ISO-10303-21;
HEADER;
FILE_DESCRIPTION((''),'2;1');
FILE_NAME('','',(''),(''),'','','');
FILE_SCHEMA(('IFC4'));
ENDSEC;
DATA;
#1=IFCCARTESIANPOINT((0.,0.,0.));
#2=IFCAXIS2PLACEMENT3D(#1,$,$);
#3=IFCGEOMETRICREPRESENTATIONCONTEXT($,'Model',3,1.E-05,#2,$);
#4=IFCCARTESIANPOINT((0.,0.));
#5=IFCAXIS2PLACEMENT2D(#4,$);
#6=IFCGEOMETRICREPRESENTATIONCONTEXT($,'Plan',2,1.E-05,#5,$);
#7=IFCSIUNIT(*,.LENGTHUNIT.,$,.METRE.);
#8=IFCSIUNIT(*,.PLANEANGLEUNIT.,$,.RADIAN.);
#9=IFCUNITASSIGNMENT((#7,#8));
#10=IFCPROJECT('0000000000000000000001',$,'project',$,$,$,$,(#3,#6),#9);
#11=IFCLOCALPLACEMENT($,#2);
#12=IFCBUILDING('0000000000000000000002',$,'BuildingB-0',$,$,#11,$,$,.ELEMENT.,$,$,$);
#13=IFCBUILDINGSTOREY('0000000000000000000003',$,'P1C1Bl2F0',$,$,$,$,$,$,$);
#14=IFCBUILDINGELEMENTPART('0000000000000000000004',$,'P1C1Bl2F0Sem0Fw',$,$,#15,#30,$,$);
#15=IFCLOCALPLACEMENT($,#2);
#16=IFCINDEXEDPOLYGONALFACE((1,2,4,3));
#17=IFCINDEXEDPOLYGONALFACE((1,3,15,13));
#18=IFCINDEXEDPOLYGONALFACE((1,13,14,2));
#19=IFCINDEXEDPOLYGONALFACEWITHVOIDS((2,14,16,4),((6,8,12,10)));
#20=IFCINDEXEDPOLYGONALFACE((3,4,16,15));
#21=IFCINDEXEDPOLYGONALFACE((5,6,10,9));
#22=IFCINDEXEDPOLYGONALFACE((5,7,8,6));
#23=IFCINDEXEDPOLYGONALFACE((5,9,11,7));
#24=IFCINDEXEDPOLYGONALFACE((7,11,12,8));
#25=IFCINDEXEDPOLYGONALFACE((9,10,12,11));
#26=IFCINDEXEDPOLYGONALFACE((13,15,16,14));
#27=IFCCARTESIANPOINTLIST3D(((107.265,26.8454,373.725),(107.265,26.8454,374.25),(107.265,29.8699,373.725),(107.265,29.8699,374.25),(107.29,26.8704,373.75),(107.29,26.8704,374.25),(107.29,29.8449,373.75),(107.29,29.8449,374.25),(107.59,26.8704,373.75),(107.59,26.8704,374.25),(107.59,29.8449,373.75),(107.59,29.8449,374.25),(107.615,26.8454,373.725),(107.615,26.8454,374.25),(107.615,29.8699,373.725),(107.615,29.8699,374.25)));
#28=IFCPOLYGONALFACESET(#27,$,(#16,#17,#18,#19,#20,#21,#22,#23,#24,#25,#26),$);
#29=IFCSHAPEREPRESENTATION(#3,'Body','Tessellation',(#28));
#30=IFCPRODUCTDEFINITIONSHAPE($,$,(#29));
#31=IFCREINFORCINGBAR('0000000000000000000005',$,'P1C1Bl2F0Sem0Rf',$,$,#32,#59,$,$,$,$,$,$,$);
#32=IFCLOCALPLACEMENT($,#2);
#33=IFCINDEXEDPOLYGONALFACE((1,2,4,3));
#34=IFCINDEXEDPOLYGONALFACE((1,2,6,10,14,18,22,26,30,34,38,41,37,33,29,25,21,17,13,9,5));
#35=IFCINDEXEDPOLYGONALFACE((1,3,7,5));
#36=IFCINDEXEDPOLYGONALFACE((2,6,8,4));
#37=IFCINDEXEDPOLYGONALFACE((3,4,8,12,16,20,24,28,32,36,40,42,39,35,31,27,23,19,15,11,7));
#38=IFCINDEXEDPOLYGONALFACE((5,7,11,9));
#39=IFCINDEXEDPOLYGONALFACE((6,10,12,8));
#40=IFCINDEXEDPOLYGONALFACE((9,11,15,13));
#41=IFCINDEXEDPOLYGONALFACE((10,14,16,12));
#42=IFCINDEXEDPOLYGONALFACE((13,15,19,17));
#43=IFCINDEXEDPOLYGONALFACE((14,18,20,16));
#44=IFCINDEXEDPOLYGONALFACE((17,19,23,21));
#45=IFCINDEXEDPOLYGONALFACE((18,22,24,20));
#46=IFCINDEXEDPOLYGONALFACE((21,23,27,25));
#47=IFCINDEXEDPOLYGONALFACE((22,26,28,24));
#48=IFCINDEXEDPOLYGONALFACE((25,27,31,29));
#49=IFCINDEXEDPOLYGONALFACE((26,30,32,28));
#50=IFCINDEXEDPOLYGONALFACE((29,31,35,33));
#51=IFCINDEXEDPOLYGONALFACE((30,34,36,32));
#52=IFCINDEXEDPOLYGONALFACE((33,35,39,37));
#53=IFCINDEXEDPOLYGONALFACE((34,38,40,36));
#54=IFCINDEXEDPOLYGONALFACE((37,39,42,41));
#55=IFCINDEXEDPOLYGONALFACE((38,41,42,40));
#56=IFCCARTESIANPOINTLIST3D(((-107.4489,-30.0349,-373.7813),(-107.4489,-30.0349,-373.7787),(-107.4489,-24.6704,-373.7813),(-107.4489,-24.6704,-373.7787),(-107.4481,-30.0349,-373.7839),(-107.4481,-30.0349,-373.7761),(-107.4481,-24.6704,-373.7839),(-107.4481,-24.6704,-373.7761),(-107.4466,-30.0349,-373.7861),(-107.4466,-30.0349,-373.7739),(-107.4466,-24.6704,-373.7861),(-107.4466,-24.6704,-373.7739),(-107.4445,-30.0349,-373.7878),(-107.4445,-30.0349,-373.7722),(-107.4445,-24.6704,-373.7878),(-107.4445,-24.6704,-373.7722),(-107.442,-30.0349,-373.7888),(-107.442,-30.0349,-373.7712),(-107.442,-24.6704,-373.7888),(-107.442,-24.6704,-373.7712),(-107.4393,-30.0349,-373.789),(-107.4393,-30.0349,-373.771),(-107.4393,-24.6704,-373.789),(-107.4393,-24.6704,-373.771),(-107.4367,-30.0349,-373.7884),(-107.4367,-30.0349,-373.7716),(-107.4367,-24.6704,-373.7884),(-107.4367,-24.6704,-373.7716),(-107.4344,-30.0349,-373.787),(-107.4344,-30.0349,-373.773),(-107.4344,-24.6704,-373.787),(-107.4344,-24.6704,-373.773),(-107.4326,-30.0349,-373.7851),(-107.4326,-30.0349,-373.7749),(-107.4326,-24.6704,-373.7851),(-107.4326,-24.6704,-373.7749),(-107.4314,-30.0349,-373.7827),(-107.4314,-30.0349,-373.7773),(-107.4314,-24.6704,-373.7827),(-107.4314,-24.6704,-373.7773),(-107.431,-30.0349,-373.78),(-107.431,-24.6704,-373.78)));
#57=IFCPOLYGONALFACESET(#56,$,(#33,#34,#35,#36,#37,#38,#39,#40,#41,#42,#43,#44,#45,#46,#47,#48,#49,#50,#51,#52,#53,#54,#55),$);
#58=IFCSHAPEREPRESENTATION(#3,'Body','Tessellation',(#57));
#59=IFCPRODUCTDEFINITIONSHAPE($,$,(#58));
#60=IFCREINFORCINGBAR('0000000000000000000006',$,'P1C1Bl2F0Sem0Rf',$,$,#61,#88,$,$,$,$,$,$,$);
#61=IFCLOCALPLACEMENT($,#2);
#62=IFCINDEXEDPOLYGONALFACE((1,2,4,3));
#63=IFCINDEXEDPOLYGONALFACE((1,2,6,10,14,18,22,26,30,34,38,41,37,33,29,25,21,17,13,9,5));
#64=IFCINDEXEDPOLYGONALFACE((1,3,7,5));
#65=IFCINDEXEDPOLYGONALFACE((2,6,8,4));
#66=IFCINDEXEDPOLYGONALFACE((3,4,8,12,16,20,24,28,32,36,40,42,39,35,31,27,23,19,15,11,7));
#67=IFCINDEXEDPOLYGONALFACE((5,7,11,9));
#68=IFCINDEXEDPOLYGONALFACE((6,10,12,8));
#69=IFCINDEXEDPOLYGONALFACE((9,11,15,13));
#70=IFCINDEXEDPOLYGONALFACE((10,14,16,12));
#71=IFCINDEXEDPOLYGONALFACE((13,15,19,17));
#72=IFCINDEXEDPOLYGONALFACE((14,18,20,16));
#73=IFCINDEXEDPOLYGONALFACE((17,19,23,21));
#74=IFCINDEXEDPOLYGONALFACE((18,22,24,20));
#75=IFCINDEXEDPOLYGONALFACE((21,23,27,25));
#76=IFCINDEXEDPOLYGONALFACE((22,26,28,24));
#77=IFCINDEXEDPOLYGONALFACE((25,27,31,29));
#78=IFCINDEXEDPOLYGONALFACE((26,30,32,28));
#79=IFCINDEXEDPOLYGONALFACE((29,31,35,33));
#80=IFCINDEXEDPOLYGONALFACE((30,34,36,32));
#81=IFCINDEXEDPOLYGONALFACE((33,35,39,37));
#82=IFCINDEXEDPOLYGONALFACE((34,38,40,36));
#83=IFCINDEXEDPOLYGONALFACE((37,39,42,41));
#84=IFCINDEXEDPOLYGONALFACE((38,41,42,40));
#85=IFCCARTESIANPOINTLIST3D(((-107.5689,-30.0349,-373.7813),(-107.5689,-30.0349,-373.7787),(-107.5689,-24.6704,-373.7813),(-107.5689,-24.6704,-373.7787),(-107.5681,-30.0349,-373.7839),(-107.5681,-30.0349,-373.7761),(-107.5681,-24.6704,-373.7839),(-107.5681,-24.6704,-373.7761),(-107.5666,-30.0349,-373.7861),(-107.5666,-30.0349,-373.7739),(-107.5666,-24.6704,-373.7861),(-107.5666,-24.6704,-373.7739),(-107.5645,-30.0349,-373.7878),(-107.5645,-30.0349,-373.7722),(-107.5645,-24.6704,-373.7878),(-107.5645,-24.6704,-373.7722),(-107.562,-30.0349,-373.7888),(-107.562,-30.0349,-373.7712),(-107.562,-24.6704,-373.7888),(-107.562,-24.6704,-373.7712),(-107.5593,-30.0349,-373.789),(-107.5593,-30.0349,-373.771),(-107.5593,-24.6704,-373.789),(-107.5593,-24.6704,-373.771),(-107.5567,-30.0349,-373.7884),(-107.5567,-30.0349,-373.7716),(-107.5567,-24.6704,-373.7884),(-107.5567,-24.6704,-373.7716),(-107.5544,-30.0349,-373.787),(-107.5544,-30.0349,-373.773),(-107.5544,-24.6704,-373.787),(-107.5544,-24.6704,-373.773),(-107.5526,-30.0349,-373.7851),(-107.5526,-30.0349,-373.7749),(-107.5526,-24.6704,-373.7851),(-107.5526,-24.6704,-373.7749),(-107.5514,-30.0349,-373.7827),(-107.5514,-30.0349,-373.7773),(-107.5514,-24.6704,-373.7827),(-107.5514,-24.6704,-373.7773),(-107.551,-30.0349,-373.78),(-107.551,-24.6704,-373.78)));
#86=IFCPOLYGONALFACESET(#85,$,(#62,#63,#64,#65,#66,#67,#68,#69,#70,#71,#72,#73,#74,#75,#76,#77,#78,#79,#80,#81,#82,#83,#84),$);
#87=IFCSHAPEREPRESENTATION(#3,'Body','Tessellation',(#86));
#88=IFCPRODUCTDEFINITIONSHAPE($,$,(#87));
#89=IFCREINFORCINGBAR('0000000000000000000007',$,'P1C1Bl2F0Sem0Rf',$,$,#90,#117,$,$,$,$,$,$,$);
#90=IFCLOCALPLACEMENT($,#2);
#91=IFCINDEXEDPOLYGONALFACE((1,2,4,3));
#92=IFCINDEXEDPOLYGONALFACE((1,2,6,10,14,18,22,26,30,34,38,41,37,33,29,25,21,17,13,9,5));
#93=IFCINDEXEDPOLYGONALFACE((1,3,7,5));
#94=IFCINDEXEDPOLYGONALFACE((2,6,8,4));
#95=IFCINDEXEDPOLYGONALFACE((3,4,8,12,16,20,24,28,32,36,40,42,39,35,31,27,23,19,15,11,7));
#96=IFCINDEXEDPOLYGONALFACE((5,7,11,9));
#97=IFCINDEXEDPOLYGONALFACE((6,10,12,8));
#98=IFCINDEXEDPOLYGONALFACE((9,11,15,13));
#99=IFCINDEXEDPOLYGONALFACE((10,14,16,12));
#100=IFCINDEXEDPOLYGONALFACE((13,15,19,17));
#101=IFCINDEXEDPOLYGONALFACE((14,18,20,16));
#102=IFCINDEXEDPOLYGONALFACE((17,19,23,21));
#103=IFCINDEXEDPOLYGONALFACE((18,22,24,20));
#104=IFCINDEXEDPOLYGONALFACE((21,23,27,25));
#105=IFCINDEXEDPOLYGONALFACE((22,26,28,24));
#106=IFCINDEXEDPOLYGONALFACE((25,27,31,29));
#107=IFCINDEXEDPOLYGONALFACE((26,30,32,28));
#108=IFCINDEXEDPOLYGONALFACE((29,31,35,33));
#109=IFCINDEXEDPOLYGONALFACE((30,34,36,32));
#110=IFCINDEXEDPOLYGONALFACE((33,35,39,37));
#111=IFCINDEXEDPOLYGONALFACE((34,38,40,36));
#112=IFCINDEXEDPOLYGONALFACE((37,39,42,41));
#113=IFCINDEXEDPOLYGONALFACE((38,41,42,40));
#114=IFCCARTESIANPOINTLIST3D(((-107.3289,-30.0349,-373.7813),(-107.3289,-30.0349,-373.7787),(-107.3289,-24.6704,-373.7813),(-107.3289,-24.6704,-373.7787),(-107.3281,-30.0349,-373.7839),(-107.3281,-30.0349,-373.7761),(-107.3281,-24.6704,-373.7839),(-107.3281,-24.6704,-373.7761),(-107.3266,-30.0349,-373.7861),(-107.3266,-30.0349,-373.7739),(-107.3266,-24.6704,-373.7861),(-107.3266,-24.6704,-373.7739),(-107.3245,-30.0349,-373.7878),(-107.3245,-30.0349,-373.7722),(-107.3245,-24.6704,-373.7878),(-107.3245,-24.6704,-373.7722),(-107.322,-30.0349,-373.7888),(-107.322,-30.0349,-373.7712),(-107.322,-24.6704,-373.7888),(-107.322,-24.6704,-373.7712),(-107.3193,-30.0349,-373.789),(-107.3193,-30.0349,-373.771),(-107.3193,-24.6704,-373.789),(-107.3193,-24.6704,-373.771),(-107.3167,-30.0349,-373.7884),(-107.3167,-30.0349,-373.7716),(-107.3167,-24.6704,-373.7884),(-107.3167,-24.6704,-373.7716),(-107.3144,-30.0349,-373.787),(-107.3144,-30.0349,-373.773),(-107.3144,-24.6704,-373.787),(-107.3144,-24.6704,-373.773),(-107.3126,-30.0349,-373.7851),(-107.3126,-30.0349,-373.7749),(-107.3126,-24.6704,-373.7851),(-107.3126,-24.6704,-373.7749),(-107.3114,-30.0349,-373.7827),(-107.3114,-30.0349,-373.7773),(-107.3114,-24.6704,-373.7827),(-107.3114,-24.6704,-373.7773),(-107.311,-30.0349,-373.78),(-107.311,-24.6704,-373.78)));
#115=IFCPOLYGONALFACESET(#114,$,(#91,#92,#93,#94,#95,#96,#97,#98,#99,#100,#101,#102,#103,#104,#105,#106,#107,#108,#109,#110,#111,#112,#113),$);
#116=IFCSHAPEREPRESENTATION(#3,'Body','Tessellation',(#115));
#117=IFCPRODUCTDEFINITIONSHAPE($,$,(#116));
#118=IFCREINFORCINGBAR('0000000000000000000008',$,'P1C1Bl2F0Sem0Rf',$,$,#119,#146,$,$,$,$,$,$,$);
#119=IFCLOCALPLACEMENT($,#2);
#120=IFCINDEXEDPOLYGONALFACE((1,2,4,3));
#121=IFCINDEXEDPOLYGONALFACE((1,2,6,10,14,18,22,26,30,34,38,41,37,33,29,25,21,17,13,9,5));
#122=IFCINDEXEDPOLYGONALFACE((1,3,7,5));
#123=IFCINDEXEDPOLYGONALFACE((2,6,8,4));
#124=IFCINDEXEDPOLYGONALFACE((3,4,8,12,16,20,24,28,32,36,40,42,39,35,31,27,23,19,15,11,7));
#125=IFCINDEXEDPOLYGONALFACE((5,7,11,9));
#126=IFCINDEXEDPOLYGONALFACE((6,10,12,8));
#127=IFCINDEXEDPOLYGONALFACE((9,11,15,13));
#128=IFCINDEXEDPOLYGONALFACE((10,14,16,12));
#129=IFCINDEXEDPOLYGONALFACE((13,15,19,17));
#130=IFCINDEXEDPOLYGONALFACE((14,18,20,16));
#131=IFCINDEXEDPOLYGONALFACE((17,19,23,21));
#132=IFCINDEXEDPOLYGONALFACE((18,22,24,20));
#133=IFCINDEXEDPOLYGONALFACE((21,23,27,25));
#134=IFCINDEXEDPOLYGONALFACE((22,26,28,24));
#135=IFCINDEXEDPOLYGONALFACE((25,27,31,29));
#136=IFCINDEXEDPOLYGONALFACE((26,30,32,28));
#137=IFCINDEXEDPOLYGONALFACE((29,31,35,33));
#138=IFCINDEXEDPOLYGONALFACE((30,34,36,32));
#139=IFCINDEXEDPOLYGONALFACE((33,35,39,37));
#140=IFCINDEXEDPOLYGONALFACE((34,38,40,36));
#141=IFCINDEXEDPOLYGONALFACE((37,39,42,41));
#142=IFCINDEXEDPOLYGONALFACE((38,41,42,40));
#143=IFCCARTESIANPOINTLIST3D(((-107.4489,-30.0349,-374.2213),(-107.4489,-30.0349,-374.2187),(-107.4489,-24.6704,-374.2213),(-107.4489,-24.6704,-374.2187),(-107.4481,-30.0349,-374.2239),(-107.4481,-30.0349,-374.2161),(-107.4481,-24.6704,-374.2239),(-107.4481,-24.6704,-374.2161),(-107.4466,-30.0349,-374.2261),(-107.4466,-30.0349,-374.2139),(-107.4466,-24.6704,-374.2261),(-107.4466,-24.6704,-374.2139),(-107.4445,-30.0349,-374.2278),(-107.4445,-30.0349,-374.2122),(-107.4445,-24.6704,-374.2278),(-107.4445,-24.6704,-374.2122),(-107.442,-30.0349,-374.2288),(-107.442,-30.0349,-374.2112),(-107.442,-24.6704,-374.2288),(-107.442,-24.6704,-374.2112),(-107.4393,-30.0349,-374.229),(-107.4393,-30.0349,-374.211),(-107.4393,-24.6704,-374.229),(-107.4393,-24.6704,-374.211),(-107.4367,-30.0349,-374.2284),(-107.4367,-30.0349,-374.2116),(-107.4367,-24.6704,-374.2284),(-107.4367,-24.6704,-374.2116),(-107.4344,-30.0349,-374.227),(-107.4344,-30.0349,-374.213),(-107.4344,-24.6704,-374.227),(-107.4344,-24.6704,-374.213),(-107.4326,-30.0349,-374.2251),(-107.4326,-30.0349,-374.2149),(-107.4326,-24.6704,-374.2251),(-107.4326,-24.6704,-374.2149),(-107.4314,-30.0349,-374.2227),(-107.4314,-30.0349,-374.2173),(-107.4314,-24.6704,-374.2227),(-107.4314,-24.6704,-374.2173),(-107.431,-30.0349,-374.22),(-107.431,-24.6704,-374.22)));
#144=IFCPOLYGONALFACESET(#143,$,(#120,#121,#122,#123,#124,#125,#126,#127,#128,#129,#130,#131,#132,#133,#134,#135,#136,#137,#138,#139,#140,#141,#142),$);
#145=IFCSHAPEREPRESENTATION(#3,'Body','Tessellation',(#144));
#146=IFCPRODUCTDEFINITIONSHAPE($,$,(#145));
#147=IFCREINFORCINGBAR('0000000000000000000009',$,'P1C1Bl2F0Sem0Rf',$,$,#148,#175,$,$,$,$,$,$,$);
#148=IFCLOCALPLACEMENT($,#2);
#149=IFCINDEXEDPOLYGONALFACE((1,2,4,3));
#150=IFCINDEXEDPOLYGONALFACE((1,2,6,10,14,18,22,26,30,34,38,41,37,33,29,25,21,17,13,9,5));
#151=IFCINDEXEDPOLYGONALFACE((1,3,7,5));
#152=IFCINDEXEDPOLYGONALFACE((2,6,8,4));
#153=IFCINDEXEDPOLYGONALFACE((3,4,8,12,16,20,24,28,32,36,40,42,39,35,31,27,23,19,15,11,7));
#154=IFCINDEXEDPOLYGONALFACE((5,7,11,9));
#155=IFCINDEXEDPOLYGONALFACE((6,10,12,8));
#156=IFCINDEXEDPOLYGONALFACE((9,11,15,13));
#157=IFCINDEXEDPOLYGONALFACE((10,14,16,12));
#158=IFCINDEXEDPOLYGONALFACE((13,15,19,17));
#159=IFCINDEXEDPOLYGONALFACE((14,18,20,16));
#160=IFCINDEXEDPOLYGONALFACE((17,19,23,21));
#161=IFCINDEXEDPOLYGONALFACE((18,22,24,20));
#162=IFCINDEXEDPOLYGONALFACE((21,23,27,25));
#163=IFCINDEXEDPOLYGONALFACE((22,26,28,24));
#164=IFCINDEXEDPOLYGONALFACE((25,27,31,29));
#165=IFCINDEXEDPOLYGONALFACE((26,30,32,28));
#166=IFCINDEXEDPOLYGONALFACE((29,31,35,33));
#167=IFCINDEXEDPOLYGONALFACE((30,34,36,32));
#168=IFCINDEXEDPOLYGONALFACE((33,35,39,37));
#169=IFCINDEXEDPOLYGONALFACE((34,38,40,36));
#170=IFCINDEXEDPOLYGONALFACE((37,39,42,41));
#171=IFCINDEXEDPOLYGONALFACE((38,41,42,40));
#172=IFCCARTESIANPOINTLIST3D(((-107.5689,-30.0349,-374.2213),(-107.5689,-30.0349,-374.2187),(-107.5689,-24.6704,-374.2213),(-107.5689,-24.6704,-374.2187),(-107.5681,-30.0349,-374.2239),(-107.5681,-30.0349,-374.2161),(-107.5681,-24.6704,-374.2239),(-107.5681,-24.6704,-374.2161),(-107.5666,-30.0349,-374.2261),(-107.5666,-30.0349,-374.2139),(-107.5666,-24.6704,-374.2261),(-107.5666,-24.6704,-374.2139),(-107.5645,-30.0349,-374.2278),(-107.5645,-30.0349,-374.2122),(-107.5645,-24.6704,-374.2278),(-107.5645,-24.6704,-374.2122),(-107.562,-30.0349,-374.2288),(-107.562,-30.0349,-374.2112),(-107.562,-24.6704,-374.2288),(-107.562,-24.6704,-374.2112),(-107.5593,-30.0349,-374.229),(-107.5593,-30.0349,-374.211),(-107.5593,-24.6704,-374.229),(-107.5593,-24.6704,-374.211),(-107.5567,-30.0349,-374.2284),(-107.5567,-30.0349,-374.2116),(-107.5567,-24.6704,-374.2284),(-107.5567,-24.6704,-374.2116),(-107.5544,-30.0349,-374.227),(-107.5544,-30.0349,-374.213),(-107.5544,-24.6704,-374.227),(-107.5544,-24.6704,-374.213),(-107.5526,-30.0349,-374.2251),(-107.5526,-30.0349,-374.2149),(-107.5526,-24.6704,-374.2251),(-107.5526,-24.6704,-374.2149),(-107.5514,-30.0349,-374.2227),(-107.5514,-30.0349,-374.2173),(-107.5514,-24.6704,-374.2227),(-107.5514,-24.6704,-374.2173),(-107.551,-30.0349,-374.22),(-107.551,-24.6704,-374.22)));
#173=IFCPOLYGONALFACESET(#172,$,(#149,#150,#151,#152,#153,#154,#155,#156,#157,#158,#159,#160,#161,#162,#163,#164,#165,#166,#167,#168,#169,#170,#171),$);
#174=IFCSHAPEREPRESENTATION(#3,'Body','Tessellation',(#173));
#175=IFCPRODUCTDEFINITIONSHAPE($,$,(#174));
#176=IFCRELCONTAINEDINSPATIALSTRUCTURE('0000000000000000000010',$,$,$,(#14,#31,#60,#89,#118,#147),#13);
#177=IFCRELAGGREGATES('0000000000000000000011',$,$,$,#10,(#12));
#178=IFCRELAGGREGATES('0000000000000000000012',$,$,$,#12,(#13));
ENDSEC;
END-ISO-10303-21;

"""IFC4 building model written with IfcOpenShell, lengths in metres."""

from ifc_helpers import new_model, entity, si_unit, origin, origin_2d, place, context, project, spatial, polyline, outline, extrude, element, save


model = new_model("IFC4")

# Units and contexts
model_context = context("Model", 3, precision=1e-05, world=origin())
plan_context = context("Plan", 2, precision=1e-05, world=origin_2d())
ifc_project = project(units=[si_unit("LENGTHUNIT", "METRE"), si_unit("PLANEANGLEUNIT", "RADIAN")], contexts=[model_context, plan_context])

# Building, storey
building_placement = place(None, origin())
building = spatial("IfcBuilding", under=ifc_project, at=building_placement, Name="BuildingB-0", CompositionType="ELEMENT")
storey = spatial("IfcBuildingStorey", under=building, Name="P1C1Bl2F0")

# Building element part, opening
building_element_part_1 = element("IfcBuildingElementPart", 1, inside=storey, Name="P1C1Bl2F0Sem0Fw", context=model_context, shape_type="SweptSolid", body=[
    extrude(outline(polyline([(107.265, 26.8454, 373.725), (107.615, 26.8454, 373.725), (107.615, 29.8699, 373.725), (107.265, 29.8699, 373.725), (107.265, 26.8454, 373.725)])), None, (0.0, 0.0, 1.0), 0.525),
])
element("IfcOpeningElement", 2, inside=storey, cuts=building_element_part_1, context=model_context, shape_type="SweptSolid", body=[
    extrude(outline(polyline([(107.29, 26.8704, 373.75), (107.59, 26.8704, 373.75), (107.59, 29.8449, 373.75), (107.29, 29.8449, 373.75), (107.29, 26.8704, 373.75)])), None, (0.0, 0.0, 1.0), 0.5),
])

# Reinforcing bars
element("IfcReinforcingBar", 3, inside=storey, Name="P1C1Bl2F0Sem0Rf", context=model_context, shape_type="SweptSolid", body=[
    entity("IfcSurfaceCurveSweptAreaSolid", entity("IfcCircleProfileDef", "AREA", None, None, 0.009), None, entity("IfcPolyline", [entity("IfcCartesianPoint", [107.44, 24.6704, 373.78]), entity("IfcCartesianPoint", [107.44, 30.0349, 373.78])]), None, None, entity("IfcPlane", entity("IfcAxis2Placement3D", entity("IfcCartesianPoint", [107.44, 24.6704, 373.78]), entity("IfcDirection", [0.0, 0.0, 1.0]), entity("IfcDirection", [1.0, 0.0, 0.0])))),
])
element("IfcReinforcingBar", 4, inside=storey, Name="P1C1Bl2F0Sem0Rf", context=model_context, shape_type="SweptSolid", body=[
    entity("IfcSurfaceCurveSweptAreaSolid", entity("IfcCircleProfileDef", "AREA", None, None, 0.009), None, entity("IfcPolyline", [entity("IfcCartesianPoint", [107.56, 24.6704, 373.78]), entity("IfcCartesianPoint", [107.56, 30.0349, 373.78])]), None, None, entity("IfcPlane", entity("IfcAxis2Placement3D", entity("IfcCartesianPoint", [107.56, 24.6704, 373.78]), entity("IfcDirection", [0.0, 0.0, 1.0]), entity("IfcDirection", [1.0, 0.0, 0.0])))),
])
element("IfcReinforcingBar", 5, inside=storey, Name="P1C1Bl2F0Sem0Rf", context=model_context, shape_type="SweptSolid", body=[
    entity("IfcSurfaceCurveSweptAreaSolid", entity("IfcCircleProfileDef", "AREA", None, None, 0.009), None, entity("IfcPolyline", [entity("IfcCartesianPoint", [107.32, 24.6704, 373.78]), entity("IfcCartesianPoint", [107.32, 30.0349, 373.78])]), None, None, entity("IfcPlane", entity("IfcAxis2Placement3D", entity("IfcCartesianPoint", [107.32, 24.6704, 373.78]), entity("IfcDirection", [0.0, 0.0, 1.0]), entity("IfcDirection", [1.0, 0.0, 0.0])))),
])
element("IfcReinforcingBar", 6, inside=storey, Name="P1C1Bl2F0Sem0Rf", context=model_context, shape_type="SweptSolid", body=[
    entity("IfcSurfaceCurveSweptAreaSolid", entity("IfcCircleProfileDef", "AREA", None, None, 0.009), None, entity("IfcPolyline", [entity("IfcCartesianPoint", [107.44, 24.6704, 374.22]), entity("IfcCartesianPoint", [107.44, 30.0349, 374.22])]), None, None, entity("IfcPlane", entity("IfcAxis2Placement3D", entity("IfcCartesianPoint", [107.44, 24.6704, 374.22]), entity("IfcDirection", [0.0, 0.0, 1.0]), entity("IfcDirection", [1.0, 0.0, 0.0])))),
])
element("IfcReinforcingBar", 7, inside=storey, Name="P1C1Bl2F0Sem0Rf", context=model_context, shape_type="SweptSolid", body=[
    entity("IfcSurfaceCurveSweptAreaSolid", entity("IfcCircleProfileDef", "AREA", None, None, 0.009), None, entity("IfcPolyline", [entity("IfcCartesianPoint", [107.56, 24.6704, 374.22]), entity("IfcCartesianPoint", [107.56, 30.0349, 374.22])]), None, None, entity("IfcPlane", entity("IfcAxis2Placement3D", entity("IfcCartesianPoint", [107.56, 24.6704, 374.22]), entity("IfcDirection", [0.0, 0.0, 1.0]), entity("IfcDirection", [1.0, 0.0, 0.0])))),
])

save(model, "model.ifc")
